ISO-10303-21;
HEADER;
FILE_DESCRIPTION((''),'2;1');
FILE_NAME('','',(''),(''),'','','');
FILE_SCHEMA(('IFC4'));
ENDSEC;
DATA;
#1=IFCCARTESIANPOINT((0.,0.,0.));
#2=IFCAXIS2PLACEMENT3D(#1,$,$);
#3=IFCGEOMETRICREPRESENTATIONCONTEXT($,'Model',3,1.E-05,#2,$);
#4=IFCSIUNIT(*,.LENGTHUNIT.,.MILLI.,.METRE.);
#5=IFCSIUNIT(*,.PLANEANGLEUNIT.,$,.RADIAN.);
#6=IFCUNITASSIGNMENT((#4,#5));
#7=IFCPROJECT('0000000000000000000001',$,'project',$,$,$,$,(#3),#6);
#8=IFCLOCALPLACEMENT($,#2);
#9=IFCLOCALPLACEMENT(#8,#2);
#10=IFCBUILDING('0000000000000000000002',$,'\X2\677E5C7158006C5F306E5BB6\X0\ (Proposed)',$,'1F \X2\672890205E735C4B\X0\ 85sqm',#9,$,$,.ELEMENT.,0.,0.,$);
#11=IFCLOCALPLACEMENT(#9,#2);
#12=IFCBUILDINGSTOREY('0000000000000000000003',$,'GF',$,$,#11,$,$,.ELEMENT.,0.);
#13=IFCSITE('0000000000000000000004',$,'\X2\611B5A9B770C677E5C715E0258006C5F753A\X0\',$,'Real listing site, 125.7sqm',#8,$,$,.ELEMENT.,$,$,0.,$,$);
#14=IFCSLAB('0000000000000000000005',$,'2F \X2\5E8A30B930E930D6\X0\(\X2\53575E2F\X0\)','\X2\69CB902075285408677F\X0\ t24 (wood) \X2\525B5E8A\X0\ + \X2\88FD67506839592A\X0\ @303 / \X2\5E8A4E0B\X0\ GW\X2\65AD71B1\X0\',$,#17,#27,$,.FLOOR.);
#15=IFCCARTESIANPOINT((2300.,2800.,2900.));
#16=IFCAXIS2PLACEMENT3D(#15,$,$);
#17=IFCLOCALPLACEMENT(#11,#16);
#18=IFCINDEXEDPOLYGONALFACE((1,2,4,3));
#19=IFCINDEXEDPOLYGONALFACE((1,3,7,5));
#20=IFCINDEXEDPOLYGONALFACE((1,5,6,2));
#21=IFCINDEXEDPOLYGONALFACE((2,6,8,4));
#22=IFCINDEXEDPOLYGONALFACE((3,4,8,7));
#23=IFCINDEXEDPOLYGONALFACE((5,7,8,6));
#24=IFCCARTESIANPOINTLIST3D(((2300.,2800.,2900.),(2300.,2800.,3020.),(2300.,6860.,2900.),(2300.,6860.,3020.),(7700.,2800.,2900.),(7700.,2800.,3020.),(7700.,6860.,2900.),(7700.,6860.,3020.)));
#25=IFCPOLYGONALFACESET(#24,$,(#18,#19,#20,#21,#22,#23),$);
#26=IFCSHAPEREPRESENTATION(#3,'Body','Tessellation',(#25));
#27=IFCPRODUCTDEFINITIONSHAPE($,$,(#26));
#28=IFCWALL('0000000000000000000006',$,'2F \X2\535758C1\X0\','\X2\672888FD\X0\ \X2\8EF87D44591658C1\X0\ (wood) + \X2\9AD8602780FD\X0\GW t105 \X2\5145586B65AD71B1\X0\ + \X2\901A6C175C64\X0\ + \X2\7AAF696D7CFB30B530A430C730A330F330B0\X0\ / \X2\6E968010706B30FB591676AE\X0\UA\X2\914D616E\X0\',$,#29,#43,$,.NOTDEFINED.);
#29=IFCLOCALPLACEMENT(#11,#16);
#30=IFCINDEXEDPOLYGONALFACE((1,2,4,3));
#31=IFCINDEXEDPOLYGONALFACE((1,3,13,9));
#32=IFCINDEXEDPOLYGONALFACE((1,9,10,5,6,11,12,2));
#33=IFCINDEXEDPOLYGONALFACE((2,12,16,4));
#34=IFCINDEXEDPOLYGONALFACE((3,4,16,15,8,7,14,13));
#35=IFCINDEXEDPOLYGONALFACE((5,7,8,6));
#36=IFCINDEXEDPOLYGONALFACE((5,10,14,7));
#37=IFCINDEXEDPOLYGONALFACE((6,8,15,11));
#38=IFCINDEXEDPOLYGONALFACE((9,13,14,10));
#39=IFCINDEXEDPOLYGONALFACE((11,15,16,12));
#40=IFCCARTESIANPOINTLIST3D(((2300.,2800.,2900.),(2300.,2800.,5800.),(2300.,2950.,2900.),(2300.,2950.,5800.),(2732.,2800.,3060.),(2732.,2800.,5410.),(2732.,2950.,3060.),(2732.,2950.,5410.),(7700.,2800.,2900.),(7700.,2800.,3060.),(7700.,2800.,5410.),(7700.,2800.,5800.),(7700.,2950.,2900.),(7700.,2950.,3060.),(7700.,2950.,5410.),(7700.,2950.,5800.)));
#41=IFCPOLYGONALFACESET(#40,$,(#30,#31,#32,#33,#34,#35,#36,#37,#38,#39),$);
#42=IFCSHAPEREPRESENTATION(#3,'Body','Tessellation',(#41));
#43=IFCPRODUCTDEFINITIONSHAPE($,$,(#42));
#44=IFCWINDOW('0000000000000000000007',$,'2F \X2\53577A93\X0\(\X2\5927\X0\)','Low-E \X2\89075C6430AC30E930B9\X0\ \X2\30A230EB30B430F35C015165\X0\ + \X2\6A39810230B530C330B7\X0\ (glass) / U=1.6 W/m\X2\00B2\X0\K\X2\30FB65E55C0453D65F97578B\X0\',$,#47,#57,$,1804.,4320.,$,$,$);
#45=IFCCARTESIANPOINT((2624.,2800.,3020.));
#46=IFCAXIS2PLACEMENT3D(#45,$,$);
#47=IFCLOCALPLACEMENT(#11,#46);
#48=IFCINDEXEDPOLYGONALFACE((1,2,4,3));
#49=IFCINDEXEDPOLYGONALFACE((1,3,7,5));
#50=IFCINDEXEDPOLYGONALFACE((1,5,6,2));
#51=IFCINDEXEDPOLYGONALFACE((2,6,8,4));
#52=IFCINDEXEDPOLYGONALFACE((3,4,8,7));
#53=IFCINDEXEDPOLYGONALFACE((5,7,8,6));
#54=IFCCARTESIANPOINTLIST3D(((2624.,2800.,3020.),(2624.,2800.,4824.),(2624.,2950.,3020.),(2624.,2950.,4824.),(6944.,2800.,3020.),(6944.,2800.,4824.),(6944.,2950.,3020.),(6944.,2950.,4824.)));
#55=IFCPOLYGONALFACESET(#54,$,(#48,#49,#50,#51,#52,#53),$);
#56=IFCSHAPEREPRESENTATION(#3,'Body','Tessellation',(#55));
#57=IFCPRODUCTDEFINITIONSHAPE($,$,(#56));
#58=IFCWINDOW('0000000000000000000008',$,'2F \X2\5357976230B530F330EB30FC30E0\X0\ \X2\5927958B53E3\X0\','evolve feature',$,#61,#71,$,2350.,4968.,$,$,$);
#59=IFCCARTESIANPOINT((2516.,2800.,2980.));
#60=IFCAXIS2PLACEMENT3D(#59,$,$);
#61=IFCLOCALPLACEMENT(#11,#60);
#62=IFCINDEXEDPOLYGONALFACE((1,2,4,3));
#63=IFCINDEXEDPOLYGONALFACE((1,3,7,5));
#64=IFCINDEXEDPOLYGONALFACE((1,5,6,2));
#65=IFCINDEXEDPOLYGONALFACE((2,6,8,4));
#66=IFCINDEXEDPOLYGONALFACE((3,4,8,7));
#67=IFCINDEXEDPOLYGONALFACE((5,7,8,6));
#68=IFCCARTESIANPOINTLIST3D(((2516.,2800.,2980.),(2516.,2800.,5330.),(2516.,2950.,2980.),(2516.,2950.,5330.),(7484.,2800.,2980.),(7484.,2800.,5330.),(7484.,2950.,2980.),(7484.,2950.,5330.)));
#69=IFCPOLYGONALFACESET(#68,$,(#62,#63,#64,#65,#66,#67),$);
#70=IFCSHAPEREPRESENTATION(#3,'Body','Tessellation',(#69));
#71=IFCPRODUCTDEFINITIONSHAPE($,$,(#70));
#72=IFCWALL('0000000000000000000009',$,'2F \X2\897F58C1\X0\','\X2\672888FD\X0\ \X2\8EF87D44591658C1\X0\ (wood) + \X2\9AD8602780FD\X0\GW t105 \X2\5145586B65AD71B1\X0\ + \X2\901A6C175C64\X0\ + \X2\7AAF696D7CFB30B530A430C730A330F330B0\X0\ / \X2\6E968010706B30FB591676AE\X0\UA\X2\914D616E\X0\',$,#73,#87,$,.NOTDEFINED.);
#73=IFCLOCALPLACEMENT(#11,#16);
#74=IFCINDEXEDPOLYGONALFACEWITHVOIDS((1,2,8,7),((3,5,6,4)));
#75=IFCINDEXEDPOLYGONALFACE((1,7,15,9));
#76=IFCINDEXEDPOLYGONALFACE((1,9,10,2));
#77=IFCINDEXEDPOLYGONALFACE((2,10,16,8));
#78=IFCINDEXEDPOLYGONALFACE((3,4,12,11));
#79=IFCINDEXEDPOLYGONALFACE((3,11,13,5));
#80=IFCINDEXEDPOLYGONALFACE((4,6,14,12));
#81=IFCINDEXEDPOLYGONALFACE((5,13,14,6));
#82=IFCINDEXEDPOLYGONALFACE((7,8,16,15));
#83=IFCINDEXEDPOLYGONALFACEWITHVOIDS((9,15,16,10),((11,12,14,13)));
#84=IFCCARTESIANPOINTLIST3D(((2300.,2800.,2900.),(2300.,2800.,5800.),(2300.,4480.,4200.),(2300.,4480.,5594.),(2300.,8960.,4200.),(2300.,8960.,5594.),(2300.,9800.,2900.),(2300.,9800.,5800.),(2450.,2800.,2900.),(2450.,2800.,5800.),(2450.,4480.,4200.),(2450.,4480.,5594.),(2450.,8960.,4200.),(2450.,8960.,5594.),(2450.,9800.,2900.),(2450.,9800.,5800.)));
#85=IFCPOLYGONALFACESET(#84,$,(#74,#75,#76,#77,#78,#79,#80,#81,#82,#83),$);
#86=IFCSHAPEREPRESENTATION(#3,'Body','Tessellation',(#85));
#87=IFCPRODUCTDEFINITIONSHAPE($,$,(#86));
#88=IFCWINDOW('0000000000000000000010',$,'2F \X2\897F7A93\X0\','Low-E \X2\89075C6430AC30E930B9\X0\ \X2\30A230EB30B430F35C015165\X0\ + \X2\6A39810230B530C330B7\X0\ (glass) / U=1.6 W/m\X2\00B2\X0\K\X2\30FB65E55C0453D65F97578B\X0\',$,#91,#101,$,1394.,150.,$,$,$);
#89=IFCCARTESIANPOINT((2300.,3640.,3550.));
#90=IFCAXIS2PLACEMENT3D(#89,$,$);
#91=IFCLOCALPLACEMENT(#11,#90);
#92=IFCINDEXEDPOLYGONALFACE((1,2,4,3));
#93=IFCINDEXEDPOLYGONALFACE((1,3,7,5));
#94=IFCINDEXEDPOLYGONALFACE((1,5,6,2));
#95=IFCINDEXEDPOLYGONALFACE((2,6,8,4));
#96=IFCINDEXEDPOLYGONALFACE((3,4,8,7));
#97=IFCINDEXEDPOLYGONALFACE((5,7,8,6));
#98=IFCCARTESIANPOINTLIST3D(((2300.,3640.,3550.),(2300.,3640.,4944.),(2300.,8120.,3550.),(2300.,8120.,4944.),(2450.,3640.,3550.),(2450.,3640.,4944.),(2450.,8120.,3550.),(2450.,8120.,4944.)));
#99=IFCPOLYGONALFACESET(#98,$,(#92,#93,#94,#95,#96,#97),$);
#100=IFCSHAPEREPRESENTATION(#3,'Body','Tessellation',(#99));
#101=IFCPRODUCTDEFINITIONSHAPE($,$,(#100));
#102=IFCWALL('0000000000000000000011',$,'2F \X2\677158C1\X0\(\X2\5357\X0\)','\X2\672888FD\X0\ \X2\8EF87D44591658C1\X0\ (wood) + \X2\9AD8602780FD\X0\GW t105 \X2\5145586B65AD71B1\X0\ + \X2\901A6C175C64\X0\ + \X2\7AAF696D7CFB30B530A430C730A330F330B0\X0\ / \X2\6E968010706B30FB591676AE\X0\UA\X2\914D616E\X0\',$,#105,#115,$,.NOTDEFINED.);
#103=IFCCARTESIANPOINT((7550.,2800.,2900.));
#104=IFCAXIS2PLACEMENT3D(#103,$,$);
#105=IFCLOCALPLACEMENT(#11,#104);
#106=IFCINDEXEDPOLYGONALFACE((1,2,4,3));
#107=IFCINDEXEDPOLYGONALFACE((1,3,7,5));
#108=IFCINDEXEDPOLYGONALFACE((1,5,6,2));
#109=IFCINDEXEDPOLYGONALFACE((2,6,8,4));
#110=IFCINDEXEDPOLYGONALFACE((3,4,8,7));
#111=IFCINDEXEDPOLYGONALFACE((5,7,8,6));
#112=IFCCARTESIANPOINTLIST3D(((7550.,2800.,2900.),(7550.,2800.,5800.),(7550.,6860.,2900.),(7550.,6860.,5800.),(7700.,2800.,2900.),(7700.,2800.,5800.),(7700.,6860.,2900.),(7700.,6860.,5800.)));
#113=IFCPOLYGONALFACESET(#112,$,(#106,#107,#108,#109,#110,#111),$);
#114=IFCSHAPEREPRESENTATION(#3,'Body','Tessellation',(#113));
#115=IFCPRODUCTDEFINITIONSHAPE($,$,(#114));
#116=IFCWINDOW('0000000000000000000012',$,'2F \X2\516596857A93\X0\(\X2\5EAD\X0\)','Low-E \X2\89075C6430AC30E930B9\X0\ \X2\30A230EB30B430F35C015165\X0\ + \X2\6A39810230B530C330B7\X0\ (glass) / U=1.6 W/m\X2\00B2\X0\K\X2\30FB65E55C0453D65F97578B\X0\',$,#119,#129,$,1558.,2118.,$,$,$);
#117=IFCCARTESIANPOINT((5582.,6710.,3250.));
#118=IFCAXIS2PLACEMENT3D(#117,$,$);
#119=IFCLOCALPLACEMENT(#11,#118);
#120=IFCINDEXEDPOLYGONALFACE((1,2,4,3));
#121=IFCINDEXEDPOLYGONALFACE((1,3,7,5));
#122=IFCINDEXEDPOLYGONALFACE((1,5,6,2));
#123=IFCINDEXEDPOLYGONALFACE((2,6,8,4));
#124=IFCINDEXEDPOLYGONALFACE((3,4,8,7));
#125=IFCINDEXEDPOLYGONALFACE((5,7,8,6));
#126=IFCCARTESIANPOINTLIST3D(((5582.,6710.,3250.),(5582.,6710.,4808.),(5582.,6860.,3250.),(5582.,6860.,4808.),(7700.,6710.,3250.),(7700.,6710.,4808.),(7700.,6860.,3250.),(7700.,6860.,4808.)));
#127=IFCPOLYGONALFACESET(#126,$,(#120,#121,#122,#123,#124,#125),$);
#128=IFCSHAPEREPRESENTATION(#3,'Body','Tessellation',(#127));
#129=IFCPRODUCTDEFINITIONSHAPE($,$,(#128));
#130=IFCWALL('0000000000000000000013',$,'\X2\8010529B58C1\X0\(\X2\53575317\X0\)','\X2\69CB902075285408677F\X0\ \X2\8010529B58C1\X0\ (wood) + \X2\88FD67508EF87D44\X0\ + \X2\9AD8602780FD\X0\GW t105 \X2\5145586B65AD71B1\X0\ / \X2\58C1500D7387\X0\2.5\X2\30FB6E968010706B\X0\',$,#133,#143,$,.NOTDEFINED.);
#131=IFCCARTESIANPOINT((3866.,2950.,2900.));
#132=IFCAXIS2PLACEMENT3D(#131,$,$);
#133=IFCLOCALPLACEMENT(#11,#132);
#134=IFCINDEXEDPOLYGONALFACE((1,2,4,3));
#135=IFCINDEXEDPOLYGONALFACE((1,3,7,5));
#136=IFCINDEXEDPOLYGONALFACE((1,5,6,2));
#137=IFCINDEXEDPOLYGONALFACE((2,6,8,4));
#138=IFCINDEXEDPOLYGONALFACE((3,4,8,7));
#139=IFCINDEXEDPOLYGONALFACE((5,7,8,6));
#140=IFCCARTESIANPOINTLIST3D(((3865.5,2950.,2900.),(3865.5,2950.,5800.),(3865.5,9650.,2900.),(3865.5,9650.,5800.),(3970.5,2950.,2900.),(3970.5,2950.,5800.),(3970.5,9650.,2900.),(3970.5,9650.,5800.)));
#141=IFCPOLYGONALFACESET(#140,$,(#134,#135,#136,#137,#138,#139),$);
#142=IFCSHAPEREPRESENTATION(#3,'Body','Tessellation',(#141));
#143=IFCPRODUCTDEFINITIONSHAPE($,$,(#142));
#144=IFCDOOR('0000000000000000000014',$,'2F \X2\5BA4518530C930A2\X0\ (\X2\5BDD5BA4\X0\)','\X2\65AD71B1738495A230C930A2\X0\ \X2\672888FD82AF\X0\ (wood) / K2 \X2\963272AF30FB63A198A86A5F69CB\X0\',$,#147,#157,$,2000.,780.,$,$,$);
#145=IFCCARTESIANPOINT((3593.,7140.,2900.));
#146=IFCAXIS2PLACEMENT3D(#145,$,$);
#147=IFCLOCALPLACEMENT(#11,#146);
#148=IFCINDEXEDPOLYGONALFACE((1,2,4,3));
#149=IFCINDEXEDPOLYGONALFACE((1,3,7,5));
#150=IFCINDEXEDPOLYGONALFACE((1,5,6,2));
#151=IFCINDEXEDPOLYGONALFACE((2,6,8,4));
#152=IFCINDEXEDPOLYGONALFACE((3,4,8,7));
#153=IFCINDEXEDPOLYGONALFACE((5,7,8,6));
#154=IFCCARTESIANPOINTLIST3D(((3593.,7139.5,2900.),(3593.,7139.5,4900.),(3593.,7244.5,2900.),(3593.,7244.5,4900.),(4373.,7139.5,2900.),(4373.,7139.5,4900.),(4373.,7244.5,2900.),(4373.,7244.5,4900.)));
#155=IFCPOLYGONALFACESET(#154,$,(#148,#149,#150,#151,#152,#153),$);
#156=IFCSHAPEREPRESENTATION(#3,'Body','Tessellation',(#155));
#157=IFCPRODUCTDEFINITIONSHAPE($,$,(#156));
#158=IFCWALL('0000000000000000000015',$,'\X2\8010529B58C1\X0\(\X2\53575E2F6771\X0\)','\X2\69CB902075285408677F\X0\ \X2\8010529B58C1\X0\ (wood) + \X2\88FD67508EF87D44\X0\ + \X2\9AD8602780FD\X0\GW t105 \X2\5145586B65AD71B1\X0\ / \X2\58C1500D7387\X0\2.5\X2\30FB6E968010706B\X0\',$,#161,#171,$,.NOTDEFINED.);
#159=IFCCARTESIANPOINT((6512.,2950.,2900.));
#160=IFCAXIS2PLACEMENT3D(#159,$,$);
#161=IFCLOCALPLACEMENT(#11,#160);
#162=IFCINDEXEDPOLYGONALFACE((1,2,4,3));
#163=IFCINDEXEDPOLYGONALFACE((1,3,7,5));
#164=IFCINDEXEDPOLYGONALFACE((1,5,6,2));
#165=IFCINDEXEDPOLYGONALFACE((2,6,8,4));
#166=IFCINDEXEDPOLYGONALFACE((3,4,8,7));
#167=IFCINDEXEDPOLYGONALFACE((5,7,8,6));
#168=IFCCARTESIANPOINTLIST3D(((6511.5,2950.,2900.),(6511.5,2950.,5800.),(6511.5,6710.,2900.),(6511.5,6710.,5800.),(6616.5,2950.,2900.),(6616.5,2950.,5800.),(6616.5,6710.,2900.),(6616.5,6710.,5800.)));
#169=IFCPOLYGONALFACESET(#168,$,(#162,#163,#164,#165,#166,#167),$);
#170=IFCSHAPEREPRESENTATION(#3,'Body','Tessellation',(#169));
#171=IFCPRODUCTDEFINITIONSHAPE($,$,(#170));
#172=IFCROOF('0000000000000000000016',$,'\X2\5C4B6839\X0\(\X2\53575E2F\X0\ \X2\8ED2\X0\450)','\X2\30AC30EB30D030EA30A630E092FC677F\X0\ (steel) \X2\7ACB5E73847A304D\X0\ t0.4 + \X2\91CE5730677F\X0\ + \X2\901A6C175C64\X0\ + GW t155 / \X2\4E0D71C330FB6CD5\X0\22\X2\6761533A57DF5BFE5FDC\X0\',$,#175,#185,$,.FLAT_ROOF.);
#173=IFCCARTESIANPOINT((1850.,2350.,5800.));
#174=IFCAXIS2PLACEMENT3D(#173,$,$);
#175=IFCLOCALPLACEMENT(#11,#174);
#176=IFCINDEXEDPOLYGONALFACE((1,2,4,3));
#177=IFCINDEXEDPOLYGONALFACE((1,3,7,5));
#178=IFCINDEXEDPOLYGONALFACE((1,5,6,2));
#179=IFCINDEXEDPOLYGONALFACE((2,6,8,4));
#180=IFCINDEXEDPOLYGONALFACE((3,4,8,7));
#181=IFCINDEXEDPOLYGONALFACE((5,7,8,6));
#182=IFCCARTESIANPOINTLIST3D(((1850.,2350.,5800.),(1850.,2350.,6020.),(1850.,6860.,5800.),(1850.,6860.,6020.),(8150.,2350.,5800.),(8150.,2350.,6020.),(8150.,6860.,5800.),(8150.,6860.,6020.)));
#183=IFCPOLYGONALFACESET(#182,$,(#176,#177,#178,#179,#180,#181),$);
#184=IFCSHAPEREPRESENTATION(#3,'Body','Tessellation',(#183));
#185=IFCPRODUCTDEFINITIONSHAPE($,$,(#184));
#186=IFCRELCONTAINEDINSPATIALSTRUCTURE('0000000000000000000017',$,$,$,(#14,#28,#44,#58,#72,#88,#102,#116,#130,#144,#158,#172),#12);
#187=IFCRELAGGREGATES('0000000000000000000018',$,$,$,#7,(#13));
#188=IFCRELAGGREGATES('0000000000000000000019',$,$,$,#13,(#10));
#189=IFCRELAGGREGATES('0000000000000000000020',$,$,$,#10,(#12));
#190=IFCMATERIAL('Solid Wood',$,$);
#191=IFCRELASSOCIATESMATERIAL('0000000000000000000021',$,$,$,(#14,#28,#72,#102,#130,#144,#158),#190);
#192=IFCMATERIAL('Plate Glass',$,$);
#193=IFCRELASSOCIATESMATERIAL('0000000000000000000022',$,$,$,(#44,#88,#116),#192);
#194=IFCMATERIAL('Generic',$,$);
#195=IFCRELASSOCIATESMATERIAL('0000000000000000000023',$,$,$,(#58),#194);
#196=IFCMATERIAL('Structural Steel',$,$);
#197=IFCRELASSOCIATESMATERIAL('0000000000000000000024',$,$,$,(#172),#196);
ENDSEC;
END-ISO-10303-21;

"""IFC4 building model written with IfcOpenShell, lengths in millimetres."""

from ifc_helpers import new_model, si_unit, frame, frame_2d, origin, place, context, project, spatial, rectangle, extrude, material, element, fill, save


model = new_model("IFC4")

# Units and contexts
model_context = context("Model", 3, precision=1e-05, world=origin())
ifc_project = project(units=[si_unit("LENGTHUNIT", "METRE", prefix="MILLI"), si_unit("PLANEANGLEUNIT", "RADIAN")], contexts=[model_context])

# Site, building, storey
site_placement = place(None, origin())
site = spatial("IfcSite", under=ifc_project, at=site_placement, Name="愛媛県松山市堀江町", ObjectType="Real listing site, 125.7sqm", CompositionType="ELEMENT", RefElevation=0.0)
building_placement = place(site_placement, origin())
building = spatial("IfcBuilding", under=site, at=building_placement, Name="松山堀江の家 (Proposed)", ObjectType="1F 木造平屋 85sqm", CompositionType="ELEMENT", ElevationOfRefHeight=0.0, ElevationOfTerrain=0.0)
storey_placement = place(building_placement, origin())
storey = spatial("IfcBuildingStorey", under=building, at=storey_placement, Name="GF", CompositionType="ELEMENT", Elevation=0.0)

# Slab
ifc_material_1 = material(Name="Solid Wood")
slab_placement = place(storey_placement, frame((2300.0, 2800.0, 2900.0)))
element("IfcSlab", 1, at=slab_placement, inside=storey, material=ifc_material_1, Name="2F 床スラブ(南帯)", Description="構造用合板 t24 (wood) 剛床 + 製材根太 @303 / 床下 GW断熱", PredefinedType="FLOOR", context=model_context, shape_type="SweptSolid", body=[
    extrude(rectangle(XDim=5400.0, YDim=4060.0, at=frame_2d((2700.0, 2030.0))), frame((2300.0, 2800.0, 2900.0)), (0.0, 0.0, 1.0), 120.0),
])

# Wall, openings, windows
wall_1_placement = place(storey_placement, frame((2300.0, 2800.0, 2900.0)))
wall_1 = element("IfcWall", 2, at=wall_1_placement, inside=storey, material=ifc_material_1, Name="2F 南壁", Description="木製 軸組外壁 (wood) + 高性能GW t105 充填断熱 + 通気層 + 窯業系サイディング / 準耐火・外皮UA配慮", PredefinedType="NOTDEFINED", context=model_context, shape_type="SweptSolid", body=[
    extrude(rectangle(XDim=5400.0, YDim=150.0, at=frame_2d((2700.0, 75.0))), frame((2300.0, 2800.0, 2900.0)), (0.0, 0.0, 1.0), 2900.0),
])
opening_1_placement = place(storey_placement, frame((2624.0, 2800.0, 3020.0)))
opening_1 = element("IfcOpeningElement", 3, at=opening_1_placement, cuts=wall_1, PredefinedType="NOTDEFINED", context=model_context, shape_type="SweptSolid", body=[
    extrude(rectangle(XDim=4320.0, YDim=150.0, at=frame_2d((2160.0, 75.0))), frame((2624.0, 2800.0, 3020.0)), (0.0, 0.0, 1.0), 1804.0),
])
opening_2_placement = place(storey_placement, frame((2516.0, 2800.0, 2980.0)))
opening_2 = element("IfcOpeningElement", 4, at=opening_2_placement, cuts=wall_1, PredefinedType="NOTDEFINED", context=model_context, shape_type="SweptSolid", body=[
    extrude(rectangle(XDim=4968.0, YDim=150.0, at=frame_2d((2484.0, 75.0))), frame((2516.0, 2800.0, 2980.0)), (0.0, 0.0, 1.0), 2350.0),
])
ifc_material_2 = material(Name="Plate Glass")
window_1_placement = place(storey_placement, frame((2624.0, 2800.0, 3020.0)))
window_1 = element("IfcWindow", 5, at=window_1_placement, inside=storey, material=ifc_material_2, Name="2F 南窓(大)", Description="Low-E 複層ガラス アルゴン封入 + 樹脂サッシ (glass) / U=1.6 W/m²K・日射取得型", OverallHeight=1804.0, OverallWidth=4320.0, context=model_context, shape_type="SweptSolid", body=[
    extrude(rectangle(XDim=4320.0, YDim=150.0, at=frame_2d((2160.0, 75.0))), frame((2624.0, 2800.0, 3020.0)), (0.0, 0.0, 1.0), 1804.0),
])
fill(opening_1, window_1)
ifc_material_3 = material(Name="Generic")
window_2_placement = place(storey_placement, frame((2516.0, 2800.0, 2980.0)))
window_2 = element("IfcWindow", 6, at=window_2_placement, inside=storey, material=ifc_material_3, Name="2F 南面サンルーム 大開口", Description="evolve feature", OverallHeight=2350.0, OverallWidth=4968.0, context=model_context, shape_type="SweptSolid", body=[
    extrude(rectangle(XDim=4968.0, YDim=150.0, at=frame_2d((2484.0, 75.0))), frame((2516.0, 2800.0, 2980.0)), (0.0, 0.0, 1.0), 2350.0),
])
fill(opening_2, window_2)

# Walls, openings, windows
wall_2_placement = place(storey_placement, frame((2300.0, 2800.0, 2900.0)))
wall_2 = element("IfcWall", 7, at=wall_2_placement, inside=storey, material=ifc_material_1, Name="2F 西壁", Description="木製 軸組外壁 (wood) + 高性能GW t105 充填断熱 + 通気層 + 窯業系サイディング / 準耐火・外皮UA配慮", PredefinedType="NOTDEFINED", context=model_context, shape_type="SweptSolid", body=[
    extrude(rectangle(XDim=150.0, YDim=7000.0, at=frame_2d((75.0, 3500.0))), frame((2300.0, 2800.0, 2900.0)), (0.0, 0.0, 1.0), 2900.0),
])
opening_3_placement = place(storey_placement, frame((2300.0, 3640.0, 3550.0)))
opening_3 = element("IfcOpeningElement", 8, at=opening_3_placement, cuts=wall_2, PredefinedType="NOTDEFINED", context=model_context, shape_type="SweptSolid", body=[
    extrude(rectangle(XDim=150.0, YDim=4480.0, at=frame_2d((75.0, 2240.0))), frame((2300.0, 3640.0, 3550.0)), (0.0, 0.0, 1.0), 1394.0),
])
window_3_placement = place(storey_placement, frame((2300.0, 3640.0, 3550.0)))
window_3 = element("IfcWindow", 9, at=window_3_placement, inside=storey, material=ifc_material_2, Name="2F 西窓", Description="Low-E 複層ガラス アルゴン封入 + 樹脂サッシ (glass) / U=1.6 W/m²K・日射取得型", OverallHeight=1394.0, OverallWidth=150.0, context=model_context, shape_type="SweptSolid", body=[
    extrude(rectangle(XDim=150.0, YDim=4480.0, at=frame_2d((75.0, 2240.0))), frame((2300.0, 3640.0, 3550.0)), (0.0, 0.0, 1.0), 1394.0),
])
fill(opening_3, window_3)
wall_3_placement = place(storey_placement, frame((7550.0, 2800.0, 2900.0)))
wall_3 = element("IfcWall", 10, at=wall_3_placement, inside=storey, material=ifc_material_1, Name="2F 東壁(南)", Description="木製 軸組外壁 (wood) + 高性能GW t105 充填断熱 + 通気層 + 窯業系サイディング / 準耐火・外皮UA配慮", PredefinedType="NOTDEFINED", context=model_context, shape_type="SweptSolid", body=[
    extrude(rectangle(XDim=150.0, YDim=4060.0, at=frame_2d((75.0, 2030.0))), frame((7550.0, 2800.0, 2900.0)), (0.0, 0.0, 1.0), 2900.0),
])
opening_4_placement = place(storey_placement, frame((5582.0, 6710.0, 3250.0)))
opening_4 = element("IfcOpeningElement", 11, at=opening_4_placement, cuts=wall_3, PredefinedType="NOTDEFINED", context=model_context, shape_type="SweptSolid", body=[
    extrude(rectangle(XDim=2118.0, YDim=150.0, at=frame_2d((1059.0, 75.0))), frame((5582.0, 6710.0, 3250.0)), (0.0, 0.0, 1.0), 1558.0),
])
window_4_placement = place(storey_placement, frame((5582.0, 6710.0, 3250.0)))
window_4 = element("IfcWindow", 12, at=window_4_placement, inside=storey, material=ifc_material_2, Name="2F 入隅窓(庭)", Description="Low-E 複層ガラス アルゴン封入 + 樹脂サッシ (glass) / U=1.6 W/m²K・日射取得型", OverallHeight=1558.0, OverallWidth=2118.0, context=model_context, shape_type="SweptSolid", body=[
    extrude(rectangle(XDim=2118.0, YDim=150.0, at=frame_2d((1059.0, 75.0))), frame((5582.0, 6710.0, 3250.0)), (0.0, 0.0, 1.0), 1558.0),
])
fill(opening_4, window_4)

# Wall, opening, door
wall_4_placement = place(storey_placement, frame((3866.0, 2950.0, 2900.0)))
wall_4 = element("IfcWall", 13, at=wall_4_placement, inside=storey, material=ifc_material_1, Name="耐力壁(南北)", Description="構造用合板 耐力壁 (wood) + 製材軸組 + 高性能GW t105 充填断熱 / 壁倍率2.5・準耐火", PredefinedType="NOTDEFINED", context=model_context, shape_type="SweptSolid", body=[
    extrude(rectangle(XDim=105.0, YDim=6700.0, at=frame_2d((52.0, 3350.0))), frame((3866.0, 2950.0, 2900.0)), (0.0, 0.0, 1.0), 2900.0),
])
opening_5_placement = place(storey_placement, frame((3593.0, 7140.0, 2900.0)))
opening_5 = element("IfcOpeningElement", 14, at=opening_5_placement, cuts=wall_4, PredefinedType="NOTDEFINED", context=model_context, shape_type="SweptSolid", body=[
    extrude(rectangle(XDim=780.0, YDim=105.0, at=frame_2d((390.0, 52.0))), frame((3593.0, 7140.0, 2900.0)), (0.0, 0.0, 1.0), 2000.0),
])
door_placement = place(storey_placement, frame((3593.0, 7140.0, 2900.0)))
door = element("IfcDoor", 15, at=door_placement, inside=storey, material=ifc_material_1, Name="2F 室内ドア (寝室)", Description="断熱玄関ドア 木製芯 (wood) / K2 防犯・採風機構", OverallHeight=2000.0, OverallWidth=780.0, context=model_context, shape_type="SweptSolid", body=[
    extrude(rectangle(XDim=780.0, YDim=105.0, at=frame_2d((390.0, 52.0))), frame((3593.0, 7140.0, 2900.0)), (0.0, 0.0, 1.0), 2000.0),
])
fill(opening_5, door)

# Wall
wall_5_placement = place(storey_placement, frame((6512.0, 2950.0, 2900.0)))
element("IfcWall", 16, at=wall_5_placement, inside=storey, material=ifc_material_1, Name="耐力壁(南帯東)", Description="構造用合板 耐力壁 (wood) + 製材軸組 + 高性能GW t105 充填断熱 / 壁倍率2.5・準耐火", PredefinedType="NOTDEFINED", context=model_context, shape_type="SweptSolid", body=[
    extrude(rectangle(XDim=105.0, YDim=3760.0, at=frame_2d((52.0, 1880.0))), frame((6512.0, 2950.0, 2900.0)), (0.0, 0.0, 1.0), 2900.0),
])

# Roof
ifc_material_4 = material(Name="Structural Steel")
for number, where, name in (
    (17, (1850.0, 2350.0, 5800.0), "屋根(南帯 軒450)"),
):
    element("IfcRoof", number, at=place(storey_placement, frame(where)), inside=storey, material=ifc_material_4, Name=name, Description="ガルバリウム鋼板 (steel) 立平葺き t0.4 + 野地板 + 通気層 + GW t155 / 不燃・法22条区域対応", PredefinedType="FLAT_ROOF", context=model_context, shape_type="SweptSolid", body=[
        extrude(rectangle(XDim=6300.0, YDim=4510.0, at=frame_2d((3150.0, 2255.0))), frame((1850.0, 2350.0, 5800.0)), (0.0, 0.0, 1.0), 220.0),
    ])

save(model, "model.ifc")
